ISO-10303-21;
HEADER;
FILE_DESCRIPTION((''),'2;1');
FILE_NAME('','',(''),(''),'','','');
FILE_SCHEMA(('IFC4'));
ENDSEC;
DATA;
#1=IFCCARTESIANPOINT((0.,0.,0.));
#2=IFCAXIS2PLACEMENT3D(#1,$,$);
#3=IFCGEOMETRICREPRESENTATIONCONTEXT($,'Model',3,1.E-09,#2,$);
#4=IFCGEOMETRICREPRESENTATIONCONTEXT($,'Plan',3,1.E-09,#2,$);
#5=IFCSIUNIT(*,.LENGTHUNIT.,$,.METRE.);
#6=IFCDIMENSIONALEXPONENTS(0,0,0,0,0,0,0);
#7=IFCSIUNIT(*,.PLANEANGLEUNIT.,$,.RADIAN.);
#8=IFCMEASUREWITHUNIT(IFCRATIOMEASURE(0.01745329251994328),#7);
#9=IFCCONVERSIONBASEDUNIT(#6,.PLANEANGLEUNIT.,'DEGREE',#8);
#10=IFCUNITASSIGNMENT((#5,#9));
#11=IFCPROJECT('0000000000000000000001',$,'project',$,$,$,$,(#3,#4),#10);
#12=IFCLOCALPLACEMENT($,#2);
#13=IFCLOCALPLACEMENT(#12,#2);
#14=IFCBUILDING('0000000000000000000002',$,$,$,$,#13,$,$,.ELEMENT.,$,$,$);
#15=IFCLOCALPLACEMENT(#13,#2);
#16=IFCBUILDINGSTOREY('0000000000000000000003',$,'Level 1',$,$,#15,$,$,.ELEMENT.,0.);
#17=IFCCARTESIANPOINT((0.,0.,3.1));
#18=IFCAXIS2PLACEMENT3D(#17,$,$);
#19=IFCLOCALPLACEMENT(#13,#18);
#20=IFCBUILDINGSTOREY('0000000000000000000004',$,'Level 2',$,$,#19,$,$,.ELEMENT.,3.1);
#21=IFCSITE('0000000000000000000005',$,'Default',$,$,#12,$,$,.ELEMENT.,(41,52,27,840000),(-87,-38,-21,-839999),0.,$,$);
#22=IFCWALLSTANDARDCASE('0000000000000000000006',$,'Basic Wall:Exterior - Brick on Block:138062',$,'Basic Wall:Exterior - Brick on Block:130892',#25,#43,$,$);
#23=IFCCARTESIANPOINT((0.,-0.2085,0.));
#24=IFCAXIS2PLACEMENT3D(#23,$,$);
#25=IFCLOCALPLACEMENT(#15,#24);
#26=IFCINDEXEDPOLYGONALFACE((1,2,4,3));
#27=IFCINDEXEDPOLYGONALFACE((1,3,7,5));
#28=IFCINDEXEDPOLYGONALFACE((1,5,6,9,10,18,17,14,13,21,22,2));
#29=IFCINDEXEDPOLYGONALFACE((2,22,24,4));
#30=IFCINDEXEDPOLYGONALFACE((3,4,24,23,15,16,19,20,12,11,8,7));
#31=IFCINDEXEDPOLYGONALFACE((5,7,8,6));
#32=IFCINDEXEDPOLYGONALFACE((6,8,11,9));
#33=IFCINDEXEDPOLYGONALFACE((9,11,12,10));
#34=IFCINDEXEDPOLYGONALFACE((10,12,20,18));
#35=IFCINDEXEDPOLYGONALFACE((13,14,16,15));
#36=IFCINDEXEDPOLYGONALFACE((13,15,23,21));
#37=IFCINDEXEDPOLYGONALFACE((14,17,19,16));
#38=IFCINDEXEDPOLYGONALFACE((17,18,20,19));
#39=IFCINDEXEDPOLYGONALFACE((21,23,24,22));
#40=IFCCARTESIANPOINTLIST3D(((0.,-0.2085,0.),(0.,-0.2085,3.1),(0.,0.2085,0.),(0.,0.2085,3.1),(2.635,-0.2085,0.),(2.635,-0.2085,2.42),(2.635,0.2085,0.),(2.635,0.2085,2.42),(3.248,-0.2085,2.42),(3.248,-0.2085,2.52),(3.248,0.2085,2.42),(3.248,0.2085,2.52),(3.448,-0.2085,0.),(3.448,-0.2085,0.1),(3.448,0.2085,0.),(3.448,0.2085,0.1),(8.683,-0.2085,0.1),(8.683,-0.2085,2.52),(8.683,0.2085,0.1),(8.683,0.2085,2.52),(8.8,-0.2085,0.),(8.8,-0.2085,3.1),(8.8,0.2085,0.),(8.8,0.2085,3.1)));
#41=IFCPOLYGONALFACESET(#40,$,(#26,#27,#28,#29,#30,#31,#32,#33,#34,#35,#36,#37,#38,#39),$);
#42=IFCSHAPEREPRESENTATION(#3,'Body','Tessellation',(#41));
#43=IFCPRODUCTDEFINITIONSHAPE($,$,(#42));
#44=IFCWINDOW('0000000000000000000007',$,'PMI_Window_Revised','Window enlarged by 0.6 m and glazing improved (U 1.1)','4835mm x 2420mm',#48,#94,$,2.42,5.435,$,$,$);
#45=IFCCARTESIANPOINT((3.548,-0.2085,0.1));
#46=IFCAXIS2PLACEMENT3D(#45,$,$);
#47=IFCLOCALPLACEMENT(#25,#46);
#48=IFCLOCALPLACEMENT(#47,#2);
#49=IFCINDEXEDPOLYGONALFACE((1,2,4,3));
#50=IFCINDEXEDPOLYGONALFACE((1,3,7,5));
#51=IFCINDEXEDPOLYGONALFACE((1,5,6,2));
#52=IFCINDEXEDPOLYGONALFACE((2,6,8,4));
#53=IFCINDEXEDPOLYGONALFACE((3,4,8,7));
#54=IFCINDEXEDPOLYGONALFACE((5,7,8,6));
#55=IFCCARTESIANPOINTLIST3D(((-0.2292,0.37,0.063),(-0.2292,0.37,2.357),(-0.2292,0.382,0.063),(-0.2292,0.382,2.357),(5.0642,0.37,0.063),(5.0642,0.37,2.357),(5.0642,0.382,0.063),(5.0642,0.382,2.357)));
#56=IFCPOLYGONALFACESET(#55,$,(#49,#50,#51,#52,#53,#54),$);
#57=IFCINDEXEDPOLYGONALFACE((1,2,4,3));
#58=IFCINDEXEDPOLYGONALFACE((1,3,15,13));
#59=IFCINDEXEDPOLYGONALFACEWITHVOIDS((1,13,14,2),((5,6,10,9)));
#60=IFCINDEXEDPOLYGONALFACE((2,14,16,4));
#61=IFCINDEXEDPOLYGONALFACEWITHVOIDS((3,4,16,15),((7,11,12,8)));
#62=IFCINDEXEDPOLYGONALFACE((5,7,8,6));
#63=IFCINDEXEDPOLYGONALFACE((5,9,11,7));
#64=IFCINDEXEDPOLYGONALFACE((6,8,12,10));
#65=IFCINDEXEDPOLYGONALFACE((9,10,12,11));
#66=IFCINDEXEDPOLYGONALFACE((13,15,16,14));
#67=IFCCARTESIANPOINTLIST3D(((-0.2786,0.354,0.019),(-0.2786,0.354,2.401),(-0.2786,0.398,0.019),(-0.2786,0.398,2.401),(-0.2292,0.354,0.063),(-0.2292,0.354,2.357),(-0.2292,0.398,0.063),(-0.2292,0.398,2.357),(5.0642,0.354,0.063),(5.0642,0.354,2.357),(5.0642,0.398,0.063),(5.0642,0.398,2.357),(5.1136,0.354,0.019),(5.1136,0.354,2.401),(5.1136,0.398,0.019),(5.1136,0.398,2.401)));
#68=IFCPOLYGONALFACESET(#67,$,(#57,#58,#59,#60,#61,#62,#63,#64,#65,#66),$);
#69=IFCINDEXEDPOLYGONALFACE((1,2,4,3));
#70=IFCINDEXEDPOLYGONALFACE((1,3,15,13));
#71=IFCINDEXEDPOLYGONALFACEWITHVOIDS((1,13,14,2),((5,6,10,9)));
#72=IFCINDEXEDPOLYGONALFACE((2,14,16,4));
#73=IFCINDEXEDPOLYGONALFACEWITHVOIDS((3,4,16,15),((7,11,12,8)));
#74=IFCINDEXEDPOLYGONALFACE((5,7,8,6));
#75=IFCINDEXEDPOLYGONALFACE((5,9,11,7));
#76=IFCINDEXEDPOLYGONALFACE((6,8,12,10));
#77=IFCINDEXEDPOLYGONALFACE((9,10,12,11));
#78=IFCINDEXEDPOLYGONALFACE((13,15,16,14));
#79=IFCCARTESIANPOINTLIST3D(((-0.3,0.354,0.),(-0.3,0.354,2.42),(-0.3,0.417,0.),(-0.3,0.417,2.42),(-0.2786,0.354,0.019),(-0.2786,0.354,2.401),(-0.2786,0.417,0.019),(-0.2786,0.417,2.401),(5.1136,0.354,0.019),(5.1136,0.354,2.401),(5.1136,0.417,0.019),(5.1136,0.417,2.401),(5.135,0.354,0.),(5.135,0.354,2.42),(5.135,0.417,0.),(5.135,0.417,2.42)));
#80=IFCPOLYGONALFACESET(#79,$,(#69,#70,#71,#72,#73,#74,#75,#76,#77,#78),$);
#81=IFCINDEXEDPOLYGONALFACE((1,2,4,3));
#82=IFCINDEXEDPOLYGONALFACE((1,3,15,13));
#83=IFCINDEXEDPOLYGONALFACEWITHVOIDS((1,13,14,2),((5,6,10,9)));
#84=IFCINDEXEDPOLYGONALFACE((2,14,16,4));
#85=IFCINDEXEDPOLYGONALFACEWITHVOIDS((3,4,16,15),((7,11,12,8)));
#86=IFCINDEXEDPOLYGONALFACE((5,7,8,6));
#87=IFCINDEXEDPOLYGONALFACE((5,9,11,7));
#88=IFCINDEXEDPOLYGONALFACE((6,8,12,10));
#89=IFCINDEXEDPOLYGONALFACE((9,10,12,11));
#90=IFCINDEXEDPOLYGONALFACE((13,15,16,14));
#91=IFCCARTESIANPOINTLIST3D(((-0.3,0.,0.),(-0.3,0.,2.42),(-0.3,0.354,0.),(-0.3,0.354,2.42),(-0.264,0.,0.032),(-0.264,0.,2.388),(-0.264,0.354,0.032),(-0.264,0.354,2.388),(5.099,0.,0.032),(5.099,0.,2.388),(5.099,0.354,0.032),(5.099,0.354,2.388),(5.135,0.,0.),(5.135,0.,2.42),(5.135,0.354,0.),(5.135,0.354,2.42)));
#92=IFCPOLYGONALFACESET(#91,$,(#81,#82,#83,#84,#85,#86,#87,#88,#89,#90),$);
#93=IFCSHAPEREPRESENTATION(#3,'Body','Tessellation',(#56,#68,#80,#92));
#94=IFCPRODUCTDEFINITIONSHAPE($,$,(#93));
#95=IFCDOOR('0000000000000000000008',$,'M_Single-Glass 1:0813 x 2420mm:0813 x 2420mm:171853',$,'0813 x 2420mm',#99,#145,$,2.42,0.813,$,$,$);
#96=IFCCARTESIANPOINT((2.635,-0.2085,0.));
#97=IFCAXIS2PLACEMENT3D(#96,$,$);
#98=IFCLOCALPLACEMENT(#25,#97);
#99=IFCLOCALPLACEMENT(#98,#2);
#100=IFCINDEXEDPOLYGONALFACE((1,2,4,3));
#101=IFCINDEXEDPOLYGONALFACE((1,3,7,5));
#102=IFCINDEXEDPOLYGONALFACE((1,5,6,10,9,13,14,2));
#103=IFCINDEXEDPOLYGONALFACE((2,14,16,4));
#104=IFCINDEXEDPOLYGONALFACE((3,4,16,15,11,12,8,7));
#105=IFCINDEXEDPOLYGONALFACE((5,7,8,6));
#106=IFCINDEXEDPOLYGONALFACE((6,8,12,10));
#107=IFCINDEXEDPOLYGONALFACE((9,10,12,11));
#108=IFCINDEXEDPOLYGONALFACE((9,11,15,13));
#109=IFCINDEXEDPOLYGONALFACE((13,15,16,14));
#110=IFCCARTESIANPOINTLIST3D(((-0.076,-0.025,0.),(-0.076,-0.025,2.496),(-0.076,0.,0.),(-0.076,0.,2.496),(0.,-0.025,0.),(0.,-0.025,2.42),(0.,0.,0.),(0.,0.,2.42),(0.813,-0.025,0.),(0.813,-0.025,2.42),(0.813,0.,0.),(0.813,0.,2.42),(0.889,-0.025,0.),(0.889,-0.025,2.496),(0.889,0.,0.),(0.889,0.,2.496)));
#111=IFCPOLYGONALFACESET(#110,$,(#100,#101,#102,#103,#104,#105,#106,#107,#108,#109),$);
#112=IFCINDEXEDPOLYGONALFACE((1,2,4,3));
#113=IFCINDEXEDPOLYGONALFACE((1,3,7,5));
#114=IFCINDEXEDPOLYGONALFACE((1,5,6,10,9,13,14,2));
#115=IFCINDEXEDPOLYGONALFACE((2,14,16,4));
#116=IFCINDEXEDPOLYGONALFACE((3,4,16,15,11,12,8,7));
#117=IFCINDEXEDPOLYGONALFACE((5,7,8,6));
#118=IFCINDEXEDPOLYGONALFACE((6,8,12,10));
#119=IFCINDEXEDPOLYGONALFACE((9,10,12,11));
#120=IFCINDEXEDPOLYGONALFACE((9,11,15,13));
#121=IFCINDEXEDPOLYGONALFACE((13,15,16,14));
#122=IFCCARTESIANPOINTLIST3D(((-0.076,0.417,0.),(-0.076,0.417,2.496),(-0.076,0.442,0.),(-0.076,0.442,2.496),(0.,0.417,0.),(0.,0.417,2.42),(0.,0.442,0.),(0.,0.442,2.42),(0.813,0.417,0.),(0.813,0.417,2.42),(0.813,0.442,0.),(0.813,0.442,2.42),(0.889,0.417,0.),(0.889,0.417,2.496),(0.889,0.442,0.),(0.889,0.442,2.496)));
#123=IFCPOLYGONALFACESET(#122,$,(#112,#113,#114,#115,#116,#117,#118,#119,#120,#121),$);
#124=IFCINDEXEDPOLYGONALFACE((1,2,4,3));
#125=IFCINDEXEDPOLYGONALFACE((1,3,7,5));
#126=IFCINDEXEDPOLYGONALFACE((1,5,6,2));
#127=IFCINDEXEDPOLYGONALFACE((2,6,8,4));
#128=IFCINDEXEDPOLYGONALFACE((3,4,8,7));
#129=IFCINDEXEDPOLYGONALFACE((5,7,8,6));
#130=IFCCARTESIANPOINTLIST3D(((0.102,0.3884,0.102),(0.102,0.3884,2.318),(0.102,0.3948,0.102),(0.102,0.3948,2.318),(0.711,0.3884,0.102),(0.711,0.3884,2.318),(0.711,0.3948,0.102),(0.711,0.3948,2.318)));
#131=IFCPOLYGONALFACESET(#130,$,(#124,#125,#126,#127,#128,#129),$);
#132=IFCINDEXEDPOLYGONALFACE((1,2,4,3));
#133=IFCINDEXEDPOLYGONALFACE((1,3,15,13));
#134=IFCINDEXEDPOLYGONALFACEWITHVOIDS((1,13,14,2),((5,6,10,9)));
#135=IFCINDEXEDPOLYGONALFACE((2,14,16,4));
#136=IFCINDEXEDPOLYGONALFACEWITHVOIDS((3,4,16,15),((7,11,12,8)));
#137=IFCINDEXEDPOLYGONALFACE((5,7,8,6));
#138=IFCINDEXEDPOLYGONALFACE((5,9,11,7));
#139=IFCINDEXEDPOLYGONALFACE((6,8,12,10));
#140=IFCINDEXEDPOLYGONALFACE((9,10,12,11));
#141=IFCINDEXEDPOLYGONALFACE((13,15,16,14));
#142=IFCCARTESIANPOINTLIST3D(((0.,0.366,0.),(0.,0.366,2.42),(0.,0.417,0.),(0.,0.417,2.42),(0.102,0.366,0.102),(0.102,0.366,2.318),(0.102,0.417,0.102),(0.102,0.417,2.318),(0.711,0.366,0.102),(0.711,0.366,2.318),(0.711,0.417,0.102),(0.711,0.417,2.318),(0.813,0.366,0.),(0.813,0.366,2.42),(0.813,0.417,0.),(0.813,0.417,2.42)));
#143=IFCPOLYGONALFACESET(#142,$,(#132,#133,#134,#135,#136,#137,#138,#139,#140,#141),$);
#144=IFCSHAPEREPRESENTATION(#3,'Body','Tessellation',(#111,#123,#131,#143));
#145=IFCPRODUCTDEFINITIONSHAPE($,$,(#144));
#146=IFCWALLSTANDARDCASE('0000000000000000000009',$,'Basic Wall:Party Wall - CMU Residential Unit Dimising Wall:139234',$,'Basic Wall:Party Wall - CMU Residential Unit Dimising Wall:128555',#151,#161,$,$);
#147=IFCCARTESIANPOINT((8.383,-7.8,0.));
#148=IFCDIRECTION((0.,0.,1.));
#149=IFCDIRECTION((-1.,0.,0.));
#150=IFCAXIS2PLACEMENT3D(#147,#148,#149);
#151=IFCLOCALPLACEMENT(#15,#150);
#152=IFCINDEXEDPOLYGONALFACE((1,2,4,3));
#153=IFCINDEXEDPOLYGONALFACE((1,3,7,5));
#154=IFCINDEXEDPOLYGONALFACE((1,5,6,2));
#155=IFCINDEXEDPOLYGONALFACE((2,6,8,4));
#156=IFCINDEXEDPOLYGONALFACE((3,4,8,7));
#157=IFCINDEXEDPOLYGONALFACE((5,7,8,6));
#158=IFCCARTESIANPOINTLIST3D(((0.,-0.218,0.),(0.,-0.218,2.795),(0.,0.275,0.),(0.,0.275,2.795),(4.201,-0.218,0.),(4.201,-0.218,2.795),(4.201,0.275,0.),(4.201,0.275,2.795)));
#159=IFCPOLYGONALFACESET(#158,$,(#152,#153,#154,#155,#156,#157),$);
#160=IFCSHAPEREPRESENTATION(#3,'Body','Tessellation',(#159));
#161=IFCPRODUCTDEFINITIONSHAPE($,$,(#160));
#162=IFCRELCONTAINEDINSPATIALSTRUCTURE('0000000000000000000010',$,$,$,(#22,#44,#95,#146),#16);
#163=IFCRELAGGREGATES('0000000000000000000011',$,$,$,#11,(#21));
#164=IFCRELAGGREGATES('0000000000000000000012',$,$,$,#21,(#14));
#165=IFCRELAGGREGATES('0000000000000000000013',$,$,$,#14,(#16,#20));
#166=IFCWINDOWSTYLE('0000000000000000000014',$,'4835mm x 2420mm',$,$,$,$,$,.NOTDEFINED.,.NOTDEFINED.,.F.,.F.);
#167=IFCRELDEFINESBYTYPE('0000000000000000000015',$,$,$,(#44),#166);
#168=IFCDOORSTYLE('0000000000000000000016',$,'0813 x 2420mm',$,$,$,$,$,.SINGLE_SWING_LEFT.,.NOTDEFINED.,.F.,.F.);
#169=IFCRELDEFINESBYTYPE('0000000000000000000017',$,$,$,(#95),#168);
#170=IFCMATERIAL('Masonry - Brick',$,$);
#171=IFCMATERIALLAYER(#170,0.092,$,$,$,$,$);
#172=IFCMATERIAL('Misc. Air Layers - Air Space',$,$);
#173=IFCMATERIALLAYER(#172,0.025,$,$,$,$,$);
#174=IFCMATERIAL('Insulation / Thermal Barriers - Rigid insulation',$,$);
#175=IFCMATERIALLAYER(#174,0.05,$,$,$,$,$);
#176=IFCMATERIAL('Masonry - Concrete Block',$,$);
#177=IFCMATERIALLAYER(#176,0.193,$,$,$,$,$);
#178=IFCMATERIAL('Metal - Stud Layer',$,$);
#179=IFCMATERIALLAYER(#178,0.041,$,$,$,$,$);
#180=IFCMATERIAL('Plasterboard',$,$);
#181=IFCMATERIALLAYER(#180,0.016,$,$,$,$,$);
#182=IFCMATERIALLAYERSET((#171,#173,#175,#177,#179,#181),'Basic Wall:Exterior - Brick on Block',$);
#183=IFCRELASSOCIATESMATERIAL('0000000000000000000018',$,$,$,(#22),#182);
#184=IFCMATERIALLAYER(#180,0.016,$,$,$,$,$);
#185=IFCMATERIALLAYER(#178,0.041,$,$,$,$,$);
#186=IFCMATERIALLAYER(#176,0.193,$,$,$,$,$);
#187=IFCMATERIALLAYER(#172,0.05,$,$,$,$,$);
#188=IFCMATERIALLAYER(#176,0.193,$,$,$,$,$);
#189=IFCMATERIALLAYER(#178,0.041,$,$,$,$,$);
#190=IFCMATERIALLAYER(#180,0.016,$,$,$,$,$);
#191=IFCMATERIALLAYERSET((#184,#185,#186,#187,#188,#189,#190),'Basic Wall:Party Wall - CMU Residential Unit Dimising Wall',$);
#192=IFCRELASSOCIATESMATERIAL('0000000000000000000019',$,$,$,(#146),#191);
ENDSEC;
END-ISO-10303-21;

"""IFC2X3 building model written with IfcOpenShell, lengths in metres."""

from ifc_helpers import new_model, entity, si_unit, converted_unit, frame, frame_2d, origin, origin_2d_with_axis, place, context, project, spatial, polyline, rectangle, outline, extrude, clip, bounded_halfspace, source, transform, mapped, material, layer, layer_set, layer_usage, type_object, type_shapes, element, fill, save


model = new_model("IFC2X3")

# Units and contexts
model_context = context("Model", 3, precision=1e-09, world=origin())
plan_context = context("Plan", 3, precision=1e-09, world=origin())
ifc_project = project(units=[si_unit("LENGTHUNIT", "METRE"), converted_unit("PLANEANGLEUNIT", "DEGREE", entity("IfcRatioMeasure", 0.01745329251994328), si_unit("PLANEANGLEUNIT", "RADIAN"), dimensions=[0, 0, 0, 0, 0, 0, 0])], contexts=[model_context, plan_context])

# Site, building, storey
site_placement = place(None, origin())
site = spatial("IfcSite", under=ifc_project, at=site_placement, Name="Default", CompositionType="ELEMENT", RefLatitude=(41, 52, 27, 840000), RefLongitude=(-87, -38, -21, -839999), RefElevation=0.0)
building_placement = place(site_placement, origin())
building = spatial("IfcBuilding", under=site, at=building_placement, CompositionType="ELEMENT")
storey_1_placement = place(building_placement, origin())
storey_1 = spatial("IfcBuildingStorey", under=building, at=storey_1_placement, Name="Level 1", CompositionType="ELEMENT", Elevation=0.0)

# Wall, openings, window, door
ifc_material_1 = material(Name="Masonry - Brick")
ifc_layer_1 = layer(ifc_material_1, 0.092)
ifc_material_2 = material(Name="Misc. Air Layers - Air Space")
ifc_layer_2 = layer(ifc_material_2, 0.025)
ifc_material_3 = material(Name="Insulation / Thermal Barriers - Rigid insulation")
ifc_layer_3 = layer(ifc_material_3, 0.05)
ifc_material_4 = material(Name="Masonry - Concrete Block")
ifc_layer_4 = layer(ifc_material_4, 0.193)
ifc_material_5 = material(Name="Metal - Stud Layer")
ifc_layer_5 = layer(ifc_material_5, 0.041)
ifc_material_6 = material(Name="Plasterboard")
ifc_layer_6 = layer(ifc_material_6, 0.016)
ifc_layer_set_1 = layer_set([ifc_layer_1, ifc_layer_2, ifc_layer_3, ifc_layer_4, ifc_layer_5, ifc_layer_6], Name="Basic Wall:Exterior - Brick on Block")
ifc_layer_usage_1 = layer_usage(ifc_layer_set_1, "AXIS2", "NEGATIVE", 0.2085)
wall_1_placement = place(storey_1_placement, frame((0.0, -0.2085, 0.0)))
wall_1 = element("IfcWallStandardCase", 1, at=wall_1_placement, inside=storey_1, material=ifc_layer_usage_1, Name="Basic Wall:Exterior - Brick on Block:138062", ObjectType="Basic Wall:Exterior - Brick on Block:130892", context=model_context, shape_type="SweptSolid", body=[
    extrude(rectangle(XDim=8.8, YDim=0.417, at=frame_2d((4.4, 0.0), x_axis=(-1.0, 0.0))), origin(), (0.0, 0.0, 1.0), 3.1),
])
opening_1_placement = place(wall_1_placement, frame((3.548, -0.2085, 0.1)))
opening_1 = element("IfcOpeningElement", 2, at=opening_1_placement, cuts=wall_1, ObjectType="Opening", context=model_context, shape_type="SweptSolid", body=[
    extrude(rectangle(XDim=2.42, YDim=5.435, at=frame_2d((1.21, 2.4175), x_axis=(1.0, 0.0))), frame((0.0, 0.0, 0.0), z_axis=(0.0, 1.0, 0.0), x_axis=(0.0, 0.0, 1.0)), (0.0, 0.0, 1.0), 0.417),
])
opening_2_placement = place(wall_1_placement, frame((2.635, -0.2085, 0.0)))
opening_2 = element("IfcOpeningElement", 3, at=opening_2_placement, cuts=wall_1, ObjectType="Opening", context=model_context, shape_type="SweptSolid", body=[
    extrude(rectangle(XDim=0.813, YDim=2.42, at=frame_2d((1.21, 0.4065), x_axis=(0.0, -1.0))), frame((0.0, 0.0, 0.0), z_axis=(0.0, 1.0, 0.0), x_axis=(0.0, 0.0, 1.0)), (0.0, 0.0, 1.0), 0.417),
])
window_style_1 = type_object("IfcWindowStyle", Name="4835mm x 2420mm", ConstructionType="NOTDEFINED", OperationType="NOTDEFINED", ParameterTakesPrecedence=False, Sizeable=False)
shared_shape_1 = source(origin(), model_context, "Body", "SweptSolid", [
    extrude(rectangle(XDim=0.012, YDim=4.709, at=origin_2d_with_axis()), frame((2.4175, 0.376, 0.063), z_axis=(0.0, 0.0, 1.0), x_axis=(0.0, -1.0, 0.0)), (0.0, 0.0, 1.0), 2.294),
    extrude(outline(polyline([(-2.3985, -1.191), (2.3985, -1.191), (2.3985, 1.191), (-2.3985, 1.191), (-2.3985, -1.191)]), holes=[polyline([(-2.3545, -1.147), (-2.3545, 1.147), (2.3545, 1.147), (2.3545, -1.147), (-2.3545, -1.147)])]), frame((2.4175, 0.354, 1.21), z_axis=(0.0, 1.0, 0.0), x_axis=(1.0, 0.0, 0.0)), (0.0, 0.0, 1.0), 0.044),
    extrude(outline(polyline([(-2.4175, -1.21), (2.4175, -1.21), (2.4175, 1.21), (-2.4175, 1.21), (-2.4175, -1.21)]), holes=[polyline([(-2.3985, -1.191), (-2.3985, 1.191), (2.3985, 1.191), (2.3985, -1.191), (-2.3985, -1.191)])]), frame((2.4175, 0.354, 1.21), z_axis=(0.0, 1.0, 0.0), x_axis=(1.0, 0.0, 0.0)), (0.0, 0.0, 1.0), 0.063),
    extrude(outline(polyline([(-2.4175, -1.21), (2.4175, -1.21), (2.4175, 1.21), (-2.4175, 1.21), (-2.4175, -1.21)]), holes=[polyline([(-2.3855, -1.178), (-2.3855, 1.178), (2.3855, 1.178), (2.3855, -1.178), (-2.3855, -1.178)])]), frame((2.4175, 0.0, 1.21), z_axis=(0.0, 1.0, 0.0), x_axis=(1.0, 0.0, 0.0)), (0.0, 0.0, 1.0), 0.354),
])
type_shapes(window_style_1, [shared_shape_1])
window_1_placement = place(opening_1_placement, origin())
window_1 = element("IfcWindow", 4, at=window_1_placement, inside=storey_1, type_object=window_style_1, Name="PMI_Window_Revised", Description="Window enlarged by 0.6 m and glazing improved (U 1.1)", ObjectType="4835mm x 2420mm", OverallHeight=2.42, OverallWidth=5.435, context=model_context, shape_type="MappedRepresentation", body=[
    mapped(shared_shape_1, transform((-0.3, 0.0, 0.0), scale=1.124095, scale2=1.0, scale3=1.0, uniform=False)),
])
fill(opening_1, window_1)
door_style_1 = type_object("IfcDoorStyle", Name="0813 x 2420mm", ConstructionType="NOTDEFINED", OperationType="SINGLE_SWING_LEFT", ParameterTakesPrecedence=False, Sizeable=False)
shared_shape_2 = source(origin(), model_context, "Body", "SweptSolid", [
    extrude(outline(polyline([(-0.4065, -1.191), (-0.4065, 1.229), (-0.4825, 1.229), (-0.4825, -1.267), (0.4825, -1.267), (0.4825, 1.229), (0.4065, 1.229), (0.4065, -1.191), (-0.4065, -1.191)])), frame((0.4065, 0.0, 1.229), z_axis=(0.0, 1.0, 0.0), x_axis=(1.0, 0.0, 0.0)), (0.0, 0.0, -1.0), 0.025),
    extrude(outline(polyline([(-0.4065, -1.191), (-0.4065, 1.229), (-0.4825, 1.229), (-0.4825, -1.267), (0.4825, -1.267), (0.4825, 1.229), (0.4065, 1.229), (0.4065, -1.191), (-0.4065, -1.191)])), frame((0.4065, 0.442, 1.229), z_axis=(0.0, 1.0, 0.0), x_axis=(1.0, 0.0, 0.0)), (0.0, 0.0, -1.0), 0.025),
    extrude(rectangle(XDim=0.609, YDim=0.0064, at=origin_2d_with_axis()), frame((0.4065, 0.3916, 0.102)), (0.0, 0.0, 1.0), 2.216),
    extrude(outline(polyline([(-1.21, -0.4065), (1.21, -0.4065), (1.21, 0.4065), (-1.21, 0.4065), (-1.21, -0.4065)]), holes=[polyline([(-1.108, 0.3045), (1.108, 0.3045), (1.108, -0.3045), (-1.108, -0.3045), (-1.108, 0.3045)])]), frame((0.4065, 0.417, 1.21), z_axis=(0.0, -1.0, 0.0), x_axis=(0.0, 0.0, -1.0)), (0.0, 0.0, 1.0), 0.051),
])
type_shapes(door_style_1, [shared_shape_2])
door_1_placement = place(opening_2_placement, origin())
door_1 = element("IfcDoor", 5, at=door_1_placement, inside=storey_1, type_object=door_style_1, Name="M_Single-Glass 1:0813 x 2420mm:0813 x 2420mm:171853", ObjectType="0813 x 2420mm", OverallHeight=2.42, OverallWidth=0.813, context=model_context, shape_type="MappedRepresentation", body=[
    mapped(shared_shape_2, transform((0.0, 0.0, 0.0), scale=1.0)),
])
fill(opening_2, door_1)

# Wall
ifc_layer_7 = layer(ifc_material_6, 0.016)
ifc_layer_8 = layer(ifc_material_5, 0.041)
ifc_layer_9 = layer(ifc_material_4, 0.193)
ifc_layer_10 = layer(ifc_material_2, 0.05)
ifc_layer_11 = layer(ifc_material_4, 0.193)
ifc_layer_12 = layer(ifc_material_5, 0.041)
ifc_layer_13 = layer(ifc_material_6, 0.016)
ifc_layer_set_2 = layer_set([ifc_layer_7, ifc_layer_8, ifc_layer_9, ifc_layer_10, ifc_layer_11, ifc_layer_12, ifc_layer_13], Name="Basic Wall:Party Wall - CMU Residential Unit Dimising Wall")
ifc_layer_usage_2 = layer_usage(ifc_layer_set_2, "AXIS2", "NEGATIVE", 0.275)
wall_2_placement = place(storey_1_placement, frame((8.383, -7.8, 0.0), z_axis=(0.0, 0.0, 1.0), x_axis=(-1.0, 0.0, 0.0)))
element("IfcWallStandardCase", 6, at=wall_2_placement, inside=storey_1, material=ifc_layer_usage_2, Name="Basic Wall:Party Wall - CMU Residential Unit Dimising Wall:139234", ObjectType="Basic Wall:Party Wall - CMU Residential Unit Dimising Wall:128555", context=model_context, shape_type="Clipping", body=[
    clip(clip(extrude(rectangle(XDim=4.201, YDim=0.55, at=frame_2d((2.1005, 0.0), x_axis=(-1.0, 0.0))), origin(), (0.0, 0.0, 1.0), 2.795), bounded_halfspace(frame((0.0, -0.218, 2.795), z_axis=(0.0, 1.0, 0.0), x_axis=(-1.0, 0.0, 0.0)), True, frame((0.0, -0.218, 2.795), z_axis=(0.0, 1.0, 0.0), x_axis=(-1.0, 0.0, 0.0)), polyline([(0.0, 0.0), (-3.708, 0.0), (-4.201, 0.0), (-4.201, -2.795), (0.0, -2.795), (0.0, 0.0)]))), bounded_halfspace(frame((4.201, 0.275, 0.0), z_axis=(-1.0, 0.0, 0.0), x_axis=(0.0, -1.0, 0.0)), True, frame((4.201, 0.275, 0.0), z_axis=(-1.0, 0.0, 0.0), x_axis=(0.0, -1.0, 0.0)), polyline([(0.0, 0.0), (0.493, 0.0), (0.493, 2.795), (0.0, 2.795), (0.0, 0.0)]))),
])

# Shared definitions
storey_2_placement = place(building_placement, frame((0.0, 0.0, 3.1)))
storey_2 = spatial("IfcBuildingStorey", under=building, at=storey_2_placement, Name="Level 2", CompositionType="ELEMENT", Elevation=3.1)

save(model, "model.ifc")
